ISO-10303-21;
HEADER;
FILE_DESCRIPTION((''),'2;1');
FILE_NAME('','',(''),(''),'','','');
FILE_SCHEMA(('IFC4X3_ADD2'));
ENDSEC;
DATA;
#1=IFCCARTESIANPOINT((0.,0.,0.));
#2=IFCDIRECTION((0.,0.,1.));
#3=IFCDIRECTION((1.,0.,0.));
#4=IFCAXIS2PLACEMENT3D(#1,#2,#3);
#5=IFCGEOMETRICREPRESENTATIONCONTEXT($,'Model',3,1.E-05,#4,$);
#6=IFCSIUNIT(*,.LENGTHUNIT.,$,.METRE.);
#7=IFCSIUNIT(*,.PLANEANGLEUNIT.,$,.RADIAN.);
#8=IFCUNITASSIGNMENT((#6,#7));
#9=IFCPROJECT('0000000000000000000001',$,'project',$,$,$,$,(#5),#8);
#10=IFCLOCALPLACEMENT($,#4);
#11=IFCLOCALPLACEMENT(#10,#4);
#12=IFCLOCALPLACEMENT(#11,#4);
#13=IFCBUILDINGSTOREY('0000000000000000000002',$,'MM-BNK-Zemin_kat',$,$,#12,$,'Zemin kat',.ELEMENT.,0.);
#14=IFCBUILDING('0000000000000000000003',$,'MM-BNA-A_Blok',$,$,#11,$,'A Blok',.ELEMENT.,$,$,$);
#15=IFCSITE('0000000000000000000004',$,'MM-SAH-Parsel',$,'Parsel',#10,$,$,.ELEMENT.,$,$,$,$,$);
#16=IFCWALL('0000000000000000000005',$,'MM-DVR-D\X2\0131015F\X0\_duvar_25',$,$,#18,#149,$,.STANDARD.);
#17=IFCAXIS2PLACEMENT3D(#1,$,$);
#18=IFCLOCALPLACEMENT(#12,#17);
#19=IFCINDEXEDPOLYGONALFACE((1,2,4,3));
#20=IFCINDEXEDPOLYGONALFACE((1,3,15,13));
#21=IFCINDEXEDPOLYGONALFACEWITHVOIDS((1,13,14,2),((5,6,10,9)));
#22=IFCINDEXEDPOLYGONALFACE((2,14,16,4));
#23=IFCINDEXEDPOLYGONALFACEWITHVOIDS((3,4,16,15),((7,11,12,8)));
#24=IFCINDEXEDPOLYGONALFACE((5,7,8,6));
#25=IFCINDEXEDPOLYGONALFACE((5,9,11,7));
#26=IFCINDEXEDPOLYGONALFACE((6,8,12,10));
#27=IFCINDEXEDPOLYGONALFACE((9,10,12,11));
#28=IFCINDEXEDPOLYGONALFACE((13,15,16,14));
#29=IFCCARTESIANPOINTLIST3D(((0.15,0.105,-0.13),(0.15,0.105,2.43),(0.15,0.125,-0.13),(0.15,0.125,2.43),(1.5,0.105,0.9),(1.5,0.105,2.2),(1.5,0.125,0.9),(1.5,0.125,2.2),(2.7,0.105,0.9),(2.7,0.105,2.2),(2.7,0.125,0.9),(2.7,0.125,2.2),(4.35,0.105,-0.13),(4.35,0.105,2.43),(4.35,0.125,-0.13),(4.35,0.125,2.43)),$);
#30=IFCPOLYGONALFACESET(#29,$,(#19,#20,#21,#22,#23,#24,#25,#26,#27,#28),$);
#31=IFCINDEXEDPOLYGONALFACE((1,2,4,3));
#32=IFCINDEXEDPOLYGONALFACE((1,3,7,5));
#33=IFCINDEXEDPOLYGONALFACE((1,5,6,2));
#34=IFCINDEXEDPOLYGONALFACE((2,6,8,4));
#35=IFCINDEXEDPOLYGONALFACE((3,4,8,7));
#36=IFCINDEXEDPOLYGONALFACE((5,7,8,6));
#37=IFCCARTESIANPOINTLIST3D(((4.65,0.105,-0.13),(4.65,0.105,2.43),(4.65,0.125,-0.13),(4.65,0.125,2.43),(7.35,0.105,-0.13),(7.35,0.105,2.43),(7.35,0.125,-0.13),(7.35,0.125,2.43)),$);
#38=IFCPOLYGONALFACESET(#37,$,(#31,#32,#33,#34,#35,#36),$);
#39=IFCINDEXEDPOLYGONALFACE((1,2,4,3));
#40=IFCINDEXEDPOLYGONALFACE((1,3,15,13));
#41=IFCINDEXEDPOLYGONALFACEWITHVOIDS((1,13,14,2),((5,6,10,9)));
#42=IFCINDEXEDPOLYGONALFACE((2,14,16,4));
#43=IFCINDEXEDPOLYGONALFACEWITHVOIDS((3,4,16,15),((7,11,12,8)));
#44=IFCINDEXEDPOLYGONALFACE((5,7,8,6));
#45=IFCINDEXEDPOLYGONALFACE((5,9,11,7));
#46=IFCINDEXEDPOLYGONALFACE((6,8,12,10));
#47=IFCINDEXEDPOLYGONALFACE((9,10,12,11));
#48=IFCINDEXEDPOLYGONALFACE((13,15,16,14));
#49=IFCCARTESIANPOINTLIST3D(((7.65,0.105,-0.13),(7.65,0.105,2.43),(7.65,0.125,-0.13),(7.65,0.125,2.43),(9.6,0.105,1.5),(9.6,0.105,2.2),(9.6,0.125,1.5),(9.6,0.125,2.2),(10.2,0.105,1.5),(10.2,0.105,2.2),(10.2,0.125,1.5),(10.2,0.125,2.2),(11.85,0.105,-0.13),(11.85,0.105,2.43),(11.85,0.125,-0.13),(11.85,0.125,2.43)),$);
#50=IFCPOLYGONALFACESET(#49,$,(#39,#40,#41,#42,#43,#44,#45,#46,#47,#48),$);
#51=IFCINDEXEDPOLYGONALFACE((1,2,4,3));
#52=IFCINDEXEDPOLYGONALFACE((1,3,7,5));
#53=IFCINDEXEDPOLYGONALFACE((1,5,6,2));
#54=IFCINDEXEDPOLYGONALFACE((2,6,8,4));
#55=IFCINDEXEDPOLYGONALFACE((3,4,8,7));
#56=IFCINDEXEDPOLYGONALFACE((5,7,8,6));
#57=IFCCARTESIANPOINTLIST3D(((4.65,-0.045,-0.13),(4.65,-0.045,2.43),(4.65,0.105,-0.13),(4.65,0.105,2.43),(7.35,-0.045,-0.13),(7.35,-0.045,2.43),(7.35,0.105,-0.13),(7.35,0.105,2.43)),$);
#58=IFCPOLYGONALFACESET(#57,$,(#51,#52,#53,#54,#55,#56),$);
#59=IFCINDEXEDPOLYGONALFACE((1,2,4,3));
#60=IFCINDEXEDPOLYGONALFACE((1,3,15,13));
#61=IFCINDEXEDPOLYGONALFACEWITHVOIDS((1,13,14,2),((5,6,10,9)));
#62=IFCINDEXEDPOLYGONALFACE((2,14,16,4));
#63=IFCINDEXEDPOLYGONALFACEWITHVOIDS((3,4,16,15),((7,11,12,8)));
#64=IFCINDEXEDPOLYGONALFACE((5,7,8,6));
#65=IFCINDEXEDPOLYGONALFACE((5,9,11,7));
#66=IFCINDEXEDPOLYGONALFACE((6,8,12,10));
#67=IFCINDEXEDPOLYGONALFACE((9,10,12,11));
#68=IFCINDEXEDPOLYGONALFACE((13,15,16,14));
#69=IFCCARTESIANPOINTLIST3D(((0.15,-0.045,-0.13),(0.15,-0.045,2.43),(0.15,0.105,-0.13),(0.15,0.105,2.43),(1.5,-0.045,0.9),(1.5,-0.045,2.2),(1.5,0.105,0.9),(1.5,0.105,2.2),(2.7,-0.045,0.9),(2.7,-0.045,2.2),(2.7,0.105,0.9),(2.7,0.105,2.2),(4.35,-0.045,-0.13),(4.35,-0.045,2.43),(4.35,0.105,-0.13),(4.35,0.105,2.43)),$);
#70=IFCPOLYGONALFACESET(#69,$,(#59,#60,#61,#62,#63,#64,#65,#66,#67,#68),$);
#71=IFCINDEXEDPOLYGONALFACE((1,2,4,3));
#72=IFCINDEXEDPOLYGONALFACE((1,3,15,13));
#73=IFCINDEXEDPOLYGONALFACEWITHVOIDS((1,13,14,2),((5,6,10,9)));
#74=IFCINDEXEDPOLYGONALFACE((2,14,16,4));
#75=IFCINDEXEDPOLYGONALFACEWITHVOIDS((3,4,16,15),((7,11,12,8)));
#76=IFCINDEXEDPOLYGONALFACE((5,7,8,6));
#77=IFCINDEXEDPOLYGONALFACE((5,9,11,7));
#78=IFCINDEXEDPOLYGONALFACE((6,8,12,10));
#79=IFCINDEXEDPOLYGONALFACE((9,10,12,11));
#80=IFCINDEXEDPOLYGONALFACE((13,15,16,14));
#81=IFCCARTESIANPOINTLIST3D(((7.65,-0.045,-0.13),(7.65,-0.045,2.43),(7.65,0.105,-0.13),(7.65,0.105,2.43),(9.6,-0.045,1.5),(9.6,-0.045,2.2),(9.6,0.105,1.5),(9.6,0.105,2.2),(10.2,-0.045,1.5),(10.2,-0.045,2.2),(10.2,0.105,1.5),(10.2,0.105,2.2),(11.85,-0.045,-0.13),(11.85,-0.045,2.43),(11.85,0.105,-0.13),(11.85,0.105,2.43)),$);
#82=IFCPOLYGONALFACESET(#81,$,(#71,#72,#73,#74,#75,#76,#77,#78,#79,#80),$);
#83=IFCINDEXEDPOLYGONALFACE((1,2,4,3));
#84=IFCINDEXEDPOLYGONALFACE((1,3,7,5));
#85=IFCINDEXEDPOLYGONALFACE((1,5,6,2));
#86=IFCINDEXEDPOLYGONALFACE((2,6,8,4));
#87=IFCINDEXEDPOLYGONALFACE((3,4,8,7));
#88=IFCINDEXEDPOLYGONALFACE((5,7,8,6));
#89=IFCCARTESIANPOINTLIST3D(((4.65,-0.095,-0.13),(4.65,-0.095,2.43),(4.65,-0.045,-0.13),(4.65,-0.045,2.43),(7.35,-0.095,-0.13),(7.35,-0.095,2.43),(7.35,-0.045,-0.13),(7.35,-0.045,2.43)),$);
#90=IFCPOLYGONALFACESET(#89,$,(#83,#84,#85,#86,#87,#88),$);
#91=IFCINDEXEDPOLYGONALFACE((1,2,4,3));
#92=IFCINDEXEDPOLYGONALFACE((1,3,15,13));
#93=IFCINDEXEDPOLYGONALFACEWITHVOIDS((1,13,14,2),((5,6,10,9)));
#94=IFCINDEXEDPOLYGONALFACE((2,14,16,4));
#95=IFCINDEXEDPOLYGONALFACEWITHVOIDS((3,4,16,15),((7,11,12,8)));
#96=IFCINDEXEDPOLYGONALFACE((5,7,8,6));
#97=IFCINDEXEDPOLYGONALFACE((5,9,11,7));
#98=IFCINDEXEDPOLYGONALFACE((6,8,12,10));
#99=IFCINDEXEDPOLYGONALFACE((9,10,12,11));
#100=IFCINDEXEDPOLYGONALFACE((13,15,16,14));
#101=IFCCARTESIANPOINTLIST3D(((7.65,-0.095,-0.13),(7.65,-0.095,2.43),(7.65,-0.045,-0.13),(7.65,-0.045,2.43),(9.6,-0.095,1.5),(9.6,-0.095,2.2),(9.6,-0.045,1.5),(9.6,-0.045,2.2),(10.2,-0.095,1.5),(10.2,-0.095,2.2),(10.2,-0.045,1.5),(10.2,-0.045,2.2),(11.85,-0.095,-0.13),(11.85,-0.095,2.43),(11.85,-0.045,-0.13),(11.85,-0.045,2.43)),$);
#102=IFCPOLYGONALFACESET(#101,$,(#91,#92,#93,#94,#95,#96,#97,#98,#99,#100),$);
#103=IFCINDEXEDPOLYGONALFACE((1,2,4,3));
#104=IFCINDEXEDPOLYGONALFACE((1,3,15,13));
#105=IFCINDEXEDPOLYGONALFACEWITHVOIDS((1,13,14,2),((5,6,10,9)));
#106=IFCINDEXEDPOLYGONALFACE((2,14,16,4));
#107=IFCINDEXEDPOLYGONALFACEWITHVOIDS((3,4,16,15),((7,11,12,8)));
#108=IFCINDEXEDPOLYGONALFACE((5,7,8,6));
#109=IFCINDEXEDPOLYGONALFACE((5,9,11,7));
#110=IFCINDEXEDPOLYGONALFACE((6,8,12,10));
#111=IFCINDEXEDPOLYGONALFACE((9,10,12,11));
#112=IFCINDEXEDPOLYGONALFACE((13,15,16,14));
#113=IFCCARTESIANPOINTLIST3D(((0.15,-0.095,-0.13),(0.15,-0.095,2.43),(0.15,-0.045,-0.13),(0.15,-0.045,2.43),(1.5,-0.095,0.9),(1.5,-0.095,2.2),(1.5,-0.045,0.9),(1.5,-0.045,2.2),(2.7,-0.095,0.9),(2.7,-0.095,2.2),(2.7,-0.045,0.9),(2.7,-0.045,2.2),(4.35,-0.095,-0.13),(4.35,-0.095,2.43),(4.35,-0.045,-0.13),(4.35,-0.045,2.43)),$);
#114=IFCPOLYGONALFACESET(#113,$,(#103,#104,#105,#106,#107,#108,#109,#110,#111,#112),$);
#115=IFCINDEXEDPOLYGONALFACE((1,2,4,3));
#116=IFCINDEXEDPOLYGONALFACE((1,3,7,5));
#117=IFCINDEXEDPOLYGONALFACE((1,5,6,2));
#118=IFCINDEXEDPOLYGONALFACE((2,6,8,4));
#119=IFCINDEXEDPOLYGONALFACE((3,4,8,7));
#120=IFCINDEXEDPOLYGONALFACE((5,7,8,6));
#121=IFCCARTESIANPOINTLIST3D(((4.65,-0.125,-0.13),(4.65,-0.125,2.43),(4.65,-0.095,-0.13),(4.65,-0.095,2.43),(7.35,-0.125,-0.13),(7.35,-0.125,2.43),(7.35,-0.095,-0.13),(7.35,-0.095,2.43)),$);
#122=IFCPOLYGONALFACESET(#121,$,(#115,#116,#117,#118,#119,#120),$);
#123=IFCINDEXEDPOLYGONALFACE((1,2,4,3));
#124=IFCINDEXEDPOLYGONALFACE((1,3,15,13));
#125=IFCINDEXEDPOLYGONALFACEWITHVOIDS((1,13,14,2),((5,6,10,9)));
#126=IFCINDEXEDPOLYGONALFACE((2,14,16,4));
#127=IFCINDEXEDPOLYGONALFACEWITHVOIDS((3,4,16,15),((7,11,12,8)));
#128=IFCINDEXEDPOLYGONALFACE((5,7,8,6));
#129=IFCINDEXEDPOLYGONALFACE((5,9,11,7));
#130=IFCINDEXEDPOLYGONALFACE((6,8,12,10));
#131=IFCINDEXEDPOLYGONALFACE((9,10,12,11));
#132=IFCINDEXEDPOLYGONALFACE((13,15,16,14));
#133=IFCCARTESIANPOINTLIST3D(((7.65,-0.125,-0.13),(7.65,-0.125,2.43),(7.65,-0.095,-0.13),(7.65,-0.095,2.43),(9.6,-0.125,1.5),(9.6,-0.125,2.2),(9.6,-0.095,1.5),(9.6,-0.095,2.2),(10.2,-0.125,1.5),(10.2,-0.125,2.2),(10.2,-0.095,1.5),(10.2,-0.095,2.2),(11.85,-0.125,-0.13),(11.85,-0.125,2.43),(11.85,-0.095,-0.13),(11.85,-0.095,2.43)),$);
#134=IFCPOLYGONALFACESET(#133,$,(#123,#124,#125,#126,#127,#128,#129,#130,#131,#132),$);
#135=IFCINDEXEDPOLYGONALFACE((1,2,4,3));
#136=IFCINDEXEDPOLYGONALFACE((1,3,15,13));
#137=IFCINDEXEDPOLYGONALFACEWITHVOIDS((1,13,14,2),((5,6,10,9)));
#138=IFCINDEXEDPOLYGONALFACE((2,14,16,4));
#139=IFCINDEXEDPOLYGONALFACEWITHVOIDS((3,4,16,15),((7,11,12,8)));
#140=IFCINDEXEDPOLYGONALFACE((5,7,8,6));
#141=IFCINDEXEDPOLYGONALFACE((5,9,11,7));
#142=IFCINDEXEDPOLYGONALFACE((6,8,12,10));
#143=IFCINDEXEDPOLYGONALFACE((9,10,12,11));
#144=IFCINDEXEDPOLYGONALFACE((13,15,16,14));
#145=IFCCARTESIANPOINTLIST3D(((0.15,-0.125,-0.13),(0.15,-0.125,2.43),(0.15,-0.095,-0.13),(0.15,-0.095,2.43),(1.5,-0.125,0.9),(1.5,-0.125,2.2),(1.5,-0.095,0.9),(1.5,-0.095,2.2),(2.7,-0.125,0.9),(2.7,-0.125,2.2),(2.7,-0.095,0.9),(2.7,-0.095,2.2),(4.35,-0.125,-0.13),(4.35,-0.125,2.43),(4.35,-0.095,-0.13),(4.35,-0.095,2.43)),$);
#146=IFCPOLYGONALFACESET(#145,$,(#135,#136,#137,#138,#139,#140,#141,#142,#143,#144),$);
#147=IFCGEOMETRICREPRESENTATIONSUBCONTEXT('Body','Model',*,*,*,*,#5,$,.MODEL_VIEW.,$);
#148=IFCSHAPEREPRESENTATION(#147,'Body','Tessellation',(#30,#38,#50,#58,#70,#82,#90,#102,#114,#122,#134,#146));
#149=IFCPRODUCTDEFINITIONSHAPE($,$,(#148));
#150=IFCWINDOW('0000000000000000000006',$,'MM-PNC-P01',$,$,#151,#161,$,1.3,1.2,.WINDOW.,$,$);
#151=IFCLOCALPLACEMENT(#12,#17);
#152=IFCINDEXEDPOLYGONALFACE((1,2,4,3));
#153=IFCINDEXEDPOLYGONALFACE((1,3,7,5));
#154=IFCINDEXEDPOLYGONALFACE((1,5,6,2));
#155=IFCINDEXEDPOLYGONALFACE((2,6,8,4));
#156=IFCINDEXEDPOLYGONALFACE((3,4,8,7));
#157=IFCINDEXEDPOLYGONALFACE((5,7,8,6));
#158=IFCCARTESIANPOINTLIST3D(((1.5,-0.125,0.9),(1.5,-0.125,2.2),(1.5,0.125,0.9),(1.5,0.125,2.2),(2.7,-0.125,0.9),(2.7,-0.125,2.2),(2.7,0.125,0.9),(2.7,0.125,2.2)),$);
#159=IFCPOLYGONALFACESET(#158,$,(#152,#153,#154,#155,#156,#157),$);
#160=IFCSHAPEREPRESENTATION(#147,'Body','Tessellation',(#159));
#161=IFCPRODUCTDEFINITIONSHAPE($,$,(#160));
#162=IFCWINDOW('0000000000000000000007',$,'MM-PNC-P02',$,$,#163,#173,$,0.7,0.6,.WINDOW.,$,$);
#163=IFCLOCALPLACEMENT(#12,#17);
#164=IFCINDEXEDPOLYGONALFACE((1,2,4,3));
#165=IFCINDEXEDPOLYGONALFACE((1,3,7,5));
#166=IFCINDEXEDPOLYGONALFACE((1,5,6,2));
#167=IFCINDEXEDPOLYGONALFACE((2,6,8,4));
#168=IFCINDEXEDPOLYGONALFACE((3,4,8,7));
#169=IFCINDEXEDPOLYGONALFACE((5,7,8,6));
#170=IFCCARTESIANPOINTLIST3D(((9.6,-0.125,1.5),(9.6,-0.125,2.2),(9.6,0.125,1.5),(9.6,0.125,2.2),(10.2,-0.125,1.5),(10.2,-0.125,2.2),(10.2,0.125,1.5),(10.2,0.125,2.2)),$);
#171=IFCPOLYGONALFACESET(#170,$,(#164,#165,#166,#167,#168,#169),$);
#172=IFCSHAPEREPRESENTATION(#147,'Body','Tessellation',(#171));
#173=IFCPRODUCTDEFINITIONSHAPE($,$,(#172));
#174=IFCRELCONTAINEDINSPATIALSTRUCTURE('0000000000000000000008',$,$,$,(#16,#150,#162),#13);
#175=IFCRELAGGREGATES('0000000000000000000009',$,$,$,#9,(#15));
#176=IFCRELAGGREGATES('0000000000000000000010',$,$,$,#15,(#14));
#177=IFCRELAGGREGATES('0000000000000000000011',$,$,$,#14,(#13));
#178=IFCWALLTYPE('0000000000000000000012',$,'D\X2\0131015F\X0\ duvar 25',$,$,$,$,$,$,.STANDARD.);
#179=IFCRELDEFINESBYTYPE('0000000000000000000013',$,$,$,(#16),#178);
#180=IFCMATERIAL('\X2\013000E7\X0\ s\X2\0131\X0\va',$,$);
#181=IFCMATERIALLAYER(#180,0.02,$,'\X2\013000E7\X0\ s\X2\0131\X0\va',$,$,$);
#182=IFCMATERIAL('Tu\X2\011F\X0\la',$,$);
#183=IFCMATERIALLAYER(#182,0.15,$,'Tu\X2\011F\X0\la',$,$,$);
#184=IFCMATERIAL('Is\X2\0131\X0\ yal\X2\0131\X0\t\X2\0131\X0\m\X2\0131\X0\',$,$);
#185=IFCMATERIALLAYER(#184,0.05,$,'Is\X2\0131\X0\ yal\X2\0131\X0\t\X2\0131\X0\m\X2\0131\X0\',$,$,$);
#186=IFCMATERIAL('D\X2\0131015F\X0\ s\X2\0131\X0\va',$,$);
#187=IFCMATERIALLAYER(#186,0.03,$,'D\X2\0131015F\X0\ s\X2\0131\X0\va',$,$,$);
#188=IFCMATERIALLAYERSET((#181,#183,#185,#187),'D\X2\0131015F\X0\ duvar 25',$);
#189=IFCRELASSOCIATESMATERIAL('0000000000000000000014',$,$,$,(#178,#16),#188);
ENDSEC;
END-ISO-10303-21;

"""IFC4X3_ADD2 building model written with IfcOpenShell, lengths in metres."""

from ifc_helpers import new_model, si_unit, frame, origin_with_axes, place, context, subcontext, project, spatial, polyline, outline, extrude, material, layer, layer_set, type_object, element, fill, save


model = new_model("IFC4X3_ADD2")

# Units and contexts
model_context = context("Model", 3, precision=1e-05, world=origin_with_axes())
body_context = subcontext(model_context, "Body", "Model", "MODEL_VIEW")
ifc_project = project(units=[si_unit("LENGTHUNIT", "METRE"), si_unit("PLANEANGLEUNIT", "RADIAN")], contexts=[model_context])

# Site, building, storey
site_placement = place(None, origin_with_axes())
site = spatial("IfcSite", under=ifc_project, at=site_placement, Name="MM-SAH-Parsel", ObjectType="Parsel", CompositionType="ELEMENT")
building_placement = place(site_placement, origin_with_axes())
building = spatial("IfcBuilding", under=site, at=building_placement, Name="MM-BNA-A_Blok", LongName="A Blok", CompositionType="ELEMENT")
storey_placement = place(building_placement, origin_with_axes())
storey = spatial("IfcBuildingStorey", under=building, at=storey_placement, Name="MM-BNK-Zemin_kat", LongName="Zemin kat", CompositionType="ELEMENT", Elevation=0.0)

# Wall, openings, windows
ifc_material_1 = material(Name="İç sıva")
ifc_layer_1 = layer(ifc_material_1, 0.02, Name="İç sıva")
ifc_material_2 = material(Name="Tuğla")
ifc_layer_2 = layer(ifc_material_2, 0.15, Name="Tuğla")
ifc_material_3 = material(Name="Isı yalıtımı")
ifc_layer_3 = layer(ifc_material_3, 0.05, Name="Isı yalıtımı")
ifc_material_4 = material(Name="Dış sıva")
ifc_layer_4 = layer(ifc_material_4, 0.03, Name="Dış sıva")
ifc_layer_set_1 = layer_set([ifc_layer_1, ifc_layer_2, ifc_layer_3, ifc_layer_4], Name="Dış duvar 25")
wall_type_1 = type_object("IfcWallType", Name="Dış duvar 25", PredefinedType="STANDARD", material=ifc_layer_set_1)
wall_1_placement = place(storey_placement, origin_with_axes())
wall_1 = element("IfcWall", 1, at=wall_1_placement, inside=storey, type_object=wall_type_1, material=ifc_layer_set_1, Name="MM-DVR-Dış_duvar_25", PredefinedType="STANDARD", context=body_context, shape_type="SweptSolid", body=[
    extrude(outline(polyline([(0.15, 0.105), (4.35, 0.105), (4.35, 0.125), (0.15, 0.125), (0.15, 0.105)])), frame((0.0, 0.0, -0.13)), (0.0, 0.0, 1.0), 2.56),
    extrude(outline(polyline([(4.65, 0.105), (7.35, 0.105), (7.35, 0.125), (4.65, 0.125), (4.65, 0.105)])), frame((0.0, 0.0, -0.13)), (0.0, 0.0, 1.0), 2.56),
    extrude(outline(polyline([(7.65, 0.105), (11.85, 0.105), (11.85, 0.125), (7.65, 0.125), (7.65, 0.105)])), frame((0.0, 0.0, -0.13)), (0.0, 0.0, 1.0), 2.56),
    extrude(outline(polyline([(4.65, -0.045), (7.35, -0.045), (7.35, 0.105), (4.65, 0.105), (4.65, -0.045)])), frame((0.0, 0.0, -0.13)), (0.0, 0.0, 1.0), 2.56),
    extrude(outline(polyline([(0.15, -0.045), (4.35, -0.045), (4.35, 0.105), (0.15, 0.105), (0.15, -0.045)])), frame((0.0, 0.0, -0.13)), (0.0, 0.0, 1.0), 2.56),
    extrude(outline(polyline([(7.65, -0.045), (11.85, -0.045), (11.85, 0.105), (7.65, 0.105), (7.65, -0.045)])), frame((0.0, 0.0, -0.13)), (0.0, 0.0, 1.0), 2.56),
    extrude(outline(polyline([(4.65, -0.095), (7.35, -0.095), (7.35, -0.045), (4.65, -0.045), (4.65, -0.095)])), frame((0.0, 0.0, -0.13)), (0.0, 0.0, 1.0), 2.56),
    extrude(outline(polyline([(7.65, -0.095), (11.85, -0.095), (11.85, -0.045), (7.65, -0.045), (7.65, -0.095)])), frame((0.0, 0.0, -0.13)), (0.0, 0.0, 1.0), 2.56),
    extrude(outline(polyline([(0.15, -0.095), (4.35, -0.095), (4.35, -0.045), (0.15, -0.045), (0.15, -0.095)])), frame((0.0, 0.0, -0.13)), (0.0, 0.0, 1.0), 2.56),
    extrude(outline(polyline([(4.65, -0.125), (7.35, -0.125), (7.35, -0.095), (4.65, -0.095), (4.65, -0.125)])), frame((0.0, 0.0, -0.13)), (0.0, 0.0, 1.0), 2.56),
    extrude(outline(polyline([(7.65, -0.125), (11.85, -0.125), (11.85, -0.095), (7.65, -0.095), (7.65, -0.125)])), frame((0.0, 0.0, -0.13)), (0.0, 0.0, 1.0), 2.56),
    extrude(outline(polyline([(0.15, -0.125), (4.35, -0.125), (4.35, -0.095), (0.15, -0.095), (0.15, -0.125)])), frame((0.0, 0.0, -0.13)), (0.0, 0.0, 1.0), 2.56),
])
opening_1_placement = place(storey_placement, origin_with_axes())
opening_1 = element("IfcOpeningElement", 2, at=opening_1_placement, cuts=wall_1, PredefinedType="OPENING", context=body_context, shape_type="SweptSolid", body=[
    extrude(outline(polyline([(1.5, 0.125), (2.7, 0.125), (2.7, -0.125), (1.5, -0.125), (1.5, 0.125)])), frame((0.0, 0.0, 0.9)), (0.0, 0.0, 1.0), 1.3),
])
opening_2_placement = place(storey_placement, origin_with_axes())
opening_2 = element("IfcOpeningElement", 3, at=opening_2_placement, cuts=wall_1, PredefinedType="OPENING", context=body_context, shape_type="SweptSolid", body=[
    extrude(outline(polyline([(9.6, 0.125), (10.2, 0.125), (10.2, -0.125), (9.6, -0.125), (9.6, 0.125)])), frame((0.0, 0.0, 1.5)), (0.0, 0.0, 1.0), 0.7),
])
window_1_placement = place(storey_placement, origin_with_axes())
window_1 = element("IfcWindow", 4, at=window_1_placement, inside=storey, Name="MM-PNC-P01", OverallHeight=1.3, OverallWidth=1.2, PredefinedType="WINDOW", context=body_context, shape_type="SweptSolid", body=[
    extrude(outline(polyline([(1.5, 0.125), (2.7, 0.125), (2.7, -0.125), (1.5, -0.125), (1.5, 0.125)])), frame((0.0, 0.0, 0.9)), (0.0, 0.0, 1.0), 1.3),
])
fill(opening_1, window_1)
window_2_placement = place(storey_placement, origin_with_axes())
window_2 = element("IfcWindow", 5, at=window_2_placement, inside=storey, Name="MM-PNC-P02", OverallHeight=0.7, OverallWidth=0.6, PredefinedType="WINDOW", context=body_context, shape_type="SweptSolid", body=[
    extrude(outline(polyline([(9.6, 0.125), (10.2, 0.125), (10.2, -0.125), (9.6, -0.125), (9.6, 0.125)])), frame((0.0, 0.0, 1.5)), (0.0, 0.0, 1.0), 0.7),
])
fill(opening_2, window_2)

save(model, "model.ifc")
